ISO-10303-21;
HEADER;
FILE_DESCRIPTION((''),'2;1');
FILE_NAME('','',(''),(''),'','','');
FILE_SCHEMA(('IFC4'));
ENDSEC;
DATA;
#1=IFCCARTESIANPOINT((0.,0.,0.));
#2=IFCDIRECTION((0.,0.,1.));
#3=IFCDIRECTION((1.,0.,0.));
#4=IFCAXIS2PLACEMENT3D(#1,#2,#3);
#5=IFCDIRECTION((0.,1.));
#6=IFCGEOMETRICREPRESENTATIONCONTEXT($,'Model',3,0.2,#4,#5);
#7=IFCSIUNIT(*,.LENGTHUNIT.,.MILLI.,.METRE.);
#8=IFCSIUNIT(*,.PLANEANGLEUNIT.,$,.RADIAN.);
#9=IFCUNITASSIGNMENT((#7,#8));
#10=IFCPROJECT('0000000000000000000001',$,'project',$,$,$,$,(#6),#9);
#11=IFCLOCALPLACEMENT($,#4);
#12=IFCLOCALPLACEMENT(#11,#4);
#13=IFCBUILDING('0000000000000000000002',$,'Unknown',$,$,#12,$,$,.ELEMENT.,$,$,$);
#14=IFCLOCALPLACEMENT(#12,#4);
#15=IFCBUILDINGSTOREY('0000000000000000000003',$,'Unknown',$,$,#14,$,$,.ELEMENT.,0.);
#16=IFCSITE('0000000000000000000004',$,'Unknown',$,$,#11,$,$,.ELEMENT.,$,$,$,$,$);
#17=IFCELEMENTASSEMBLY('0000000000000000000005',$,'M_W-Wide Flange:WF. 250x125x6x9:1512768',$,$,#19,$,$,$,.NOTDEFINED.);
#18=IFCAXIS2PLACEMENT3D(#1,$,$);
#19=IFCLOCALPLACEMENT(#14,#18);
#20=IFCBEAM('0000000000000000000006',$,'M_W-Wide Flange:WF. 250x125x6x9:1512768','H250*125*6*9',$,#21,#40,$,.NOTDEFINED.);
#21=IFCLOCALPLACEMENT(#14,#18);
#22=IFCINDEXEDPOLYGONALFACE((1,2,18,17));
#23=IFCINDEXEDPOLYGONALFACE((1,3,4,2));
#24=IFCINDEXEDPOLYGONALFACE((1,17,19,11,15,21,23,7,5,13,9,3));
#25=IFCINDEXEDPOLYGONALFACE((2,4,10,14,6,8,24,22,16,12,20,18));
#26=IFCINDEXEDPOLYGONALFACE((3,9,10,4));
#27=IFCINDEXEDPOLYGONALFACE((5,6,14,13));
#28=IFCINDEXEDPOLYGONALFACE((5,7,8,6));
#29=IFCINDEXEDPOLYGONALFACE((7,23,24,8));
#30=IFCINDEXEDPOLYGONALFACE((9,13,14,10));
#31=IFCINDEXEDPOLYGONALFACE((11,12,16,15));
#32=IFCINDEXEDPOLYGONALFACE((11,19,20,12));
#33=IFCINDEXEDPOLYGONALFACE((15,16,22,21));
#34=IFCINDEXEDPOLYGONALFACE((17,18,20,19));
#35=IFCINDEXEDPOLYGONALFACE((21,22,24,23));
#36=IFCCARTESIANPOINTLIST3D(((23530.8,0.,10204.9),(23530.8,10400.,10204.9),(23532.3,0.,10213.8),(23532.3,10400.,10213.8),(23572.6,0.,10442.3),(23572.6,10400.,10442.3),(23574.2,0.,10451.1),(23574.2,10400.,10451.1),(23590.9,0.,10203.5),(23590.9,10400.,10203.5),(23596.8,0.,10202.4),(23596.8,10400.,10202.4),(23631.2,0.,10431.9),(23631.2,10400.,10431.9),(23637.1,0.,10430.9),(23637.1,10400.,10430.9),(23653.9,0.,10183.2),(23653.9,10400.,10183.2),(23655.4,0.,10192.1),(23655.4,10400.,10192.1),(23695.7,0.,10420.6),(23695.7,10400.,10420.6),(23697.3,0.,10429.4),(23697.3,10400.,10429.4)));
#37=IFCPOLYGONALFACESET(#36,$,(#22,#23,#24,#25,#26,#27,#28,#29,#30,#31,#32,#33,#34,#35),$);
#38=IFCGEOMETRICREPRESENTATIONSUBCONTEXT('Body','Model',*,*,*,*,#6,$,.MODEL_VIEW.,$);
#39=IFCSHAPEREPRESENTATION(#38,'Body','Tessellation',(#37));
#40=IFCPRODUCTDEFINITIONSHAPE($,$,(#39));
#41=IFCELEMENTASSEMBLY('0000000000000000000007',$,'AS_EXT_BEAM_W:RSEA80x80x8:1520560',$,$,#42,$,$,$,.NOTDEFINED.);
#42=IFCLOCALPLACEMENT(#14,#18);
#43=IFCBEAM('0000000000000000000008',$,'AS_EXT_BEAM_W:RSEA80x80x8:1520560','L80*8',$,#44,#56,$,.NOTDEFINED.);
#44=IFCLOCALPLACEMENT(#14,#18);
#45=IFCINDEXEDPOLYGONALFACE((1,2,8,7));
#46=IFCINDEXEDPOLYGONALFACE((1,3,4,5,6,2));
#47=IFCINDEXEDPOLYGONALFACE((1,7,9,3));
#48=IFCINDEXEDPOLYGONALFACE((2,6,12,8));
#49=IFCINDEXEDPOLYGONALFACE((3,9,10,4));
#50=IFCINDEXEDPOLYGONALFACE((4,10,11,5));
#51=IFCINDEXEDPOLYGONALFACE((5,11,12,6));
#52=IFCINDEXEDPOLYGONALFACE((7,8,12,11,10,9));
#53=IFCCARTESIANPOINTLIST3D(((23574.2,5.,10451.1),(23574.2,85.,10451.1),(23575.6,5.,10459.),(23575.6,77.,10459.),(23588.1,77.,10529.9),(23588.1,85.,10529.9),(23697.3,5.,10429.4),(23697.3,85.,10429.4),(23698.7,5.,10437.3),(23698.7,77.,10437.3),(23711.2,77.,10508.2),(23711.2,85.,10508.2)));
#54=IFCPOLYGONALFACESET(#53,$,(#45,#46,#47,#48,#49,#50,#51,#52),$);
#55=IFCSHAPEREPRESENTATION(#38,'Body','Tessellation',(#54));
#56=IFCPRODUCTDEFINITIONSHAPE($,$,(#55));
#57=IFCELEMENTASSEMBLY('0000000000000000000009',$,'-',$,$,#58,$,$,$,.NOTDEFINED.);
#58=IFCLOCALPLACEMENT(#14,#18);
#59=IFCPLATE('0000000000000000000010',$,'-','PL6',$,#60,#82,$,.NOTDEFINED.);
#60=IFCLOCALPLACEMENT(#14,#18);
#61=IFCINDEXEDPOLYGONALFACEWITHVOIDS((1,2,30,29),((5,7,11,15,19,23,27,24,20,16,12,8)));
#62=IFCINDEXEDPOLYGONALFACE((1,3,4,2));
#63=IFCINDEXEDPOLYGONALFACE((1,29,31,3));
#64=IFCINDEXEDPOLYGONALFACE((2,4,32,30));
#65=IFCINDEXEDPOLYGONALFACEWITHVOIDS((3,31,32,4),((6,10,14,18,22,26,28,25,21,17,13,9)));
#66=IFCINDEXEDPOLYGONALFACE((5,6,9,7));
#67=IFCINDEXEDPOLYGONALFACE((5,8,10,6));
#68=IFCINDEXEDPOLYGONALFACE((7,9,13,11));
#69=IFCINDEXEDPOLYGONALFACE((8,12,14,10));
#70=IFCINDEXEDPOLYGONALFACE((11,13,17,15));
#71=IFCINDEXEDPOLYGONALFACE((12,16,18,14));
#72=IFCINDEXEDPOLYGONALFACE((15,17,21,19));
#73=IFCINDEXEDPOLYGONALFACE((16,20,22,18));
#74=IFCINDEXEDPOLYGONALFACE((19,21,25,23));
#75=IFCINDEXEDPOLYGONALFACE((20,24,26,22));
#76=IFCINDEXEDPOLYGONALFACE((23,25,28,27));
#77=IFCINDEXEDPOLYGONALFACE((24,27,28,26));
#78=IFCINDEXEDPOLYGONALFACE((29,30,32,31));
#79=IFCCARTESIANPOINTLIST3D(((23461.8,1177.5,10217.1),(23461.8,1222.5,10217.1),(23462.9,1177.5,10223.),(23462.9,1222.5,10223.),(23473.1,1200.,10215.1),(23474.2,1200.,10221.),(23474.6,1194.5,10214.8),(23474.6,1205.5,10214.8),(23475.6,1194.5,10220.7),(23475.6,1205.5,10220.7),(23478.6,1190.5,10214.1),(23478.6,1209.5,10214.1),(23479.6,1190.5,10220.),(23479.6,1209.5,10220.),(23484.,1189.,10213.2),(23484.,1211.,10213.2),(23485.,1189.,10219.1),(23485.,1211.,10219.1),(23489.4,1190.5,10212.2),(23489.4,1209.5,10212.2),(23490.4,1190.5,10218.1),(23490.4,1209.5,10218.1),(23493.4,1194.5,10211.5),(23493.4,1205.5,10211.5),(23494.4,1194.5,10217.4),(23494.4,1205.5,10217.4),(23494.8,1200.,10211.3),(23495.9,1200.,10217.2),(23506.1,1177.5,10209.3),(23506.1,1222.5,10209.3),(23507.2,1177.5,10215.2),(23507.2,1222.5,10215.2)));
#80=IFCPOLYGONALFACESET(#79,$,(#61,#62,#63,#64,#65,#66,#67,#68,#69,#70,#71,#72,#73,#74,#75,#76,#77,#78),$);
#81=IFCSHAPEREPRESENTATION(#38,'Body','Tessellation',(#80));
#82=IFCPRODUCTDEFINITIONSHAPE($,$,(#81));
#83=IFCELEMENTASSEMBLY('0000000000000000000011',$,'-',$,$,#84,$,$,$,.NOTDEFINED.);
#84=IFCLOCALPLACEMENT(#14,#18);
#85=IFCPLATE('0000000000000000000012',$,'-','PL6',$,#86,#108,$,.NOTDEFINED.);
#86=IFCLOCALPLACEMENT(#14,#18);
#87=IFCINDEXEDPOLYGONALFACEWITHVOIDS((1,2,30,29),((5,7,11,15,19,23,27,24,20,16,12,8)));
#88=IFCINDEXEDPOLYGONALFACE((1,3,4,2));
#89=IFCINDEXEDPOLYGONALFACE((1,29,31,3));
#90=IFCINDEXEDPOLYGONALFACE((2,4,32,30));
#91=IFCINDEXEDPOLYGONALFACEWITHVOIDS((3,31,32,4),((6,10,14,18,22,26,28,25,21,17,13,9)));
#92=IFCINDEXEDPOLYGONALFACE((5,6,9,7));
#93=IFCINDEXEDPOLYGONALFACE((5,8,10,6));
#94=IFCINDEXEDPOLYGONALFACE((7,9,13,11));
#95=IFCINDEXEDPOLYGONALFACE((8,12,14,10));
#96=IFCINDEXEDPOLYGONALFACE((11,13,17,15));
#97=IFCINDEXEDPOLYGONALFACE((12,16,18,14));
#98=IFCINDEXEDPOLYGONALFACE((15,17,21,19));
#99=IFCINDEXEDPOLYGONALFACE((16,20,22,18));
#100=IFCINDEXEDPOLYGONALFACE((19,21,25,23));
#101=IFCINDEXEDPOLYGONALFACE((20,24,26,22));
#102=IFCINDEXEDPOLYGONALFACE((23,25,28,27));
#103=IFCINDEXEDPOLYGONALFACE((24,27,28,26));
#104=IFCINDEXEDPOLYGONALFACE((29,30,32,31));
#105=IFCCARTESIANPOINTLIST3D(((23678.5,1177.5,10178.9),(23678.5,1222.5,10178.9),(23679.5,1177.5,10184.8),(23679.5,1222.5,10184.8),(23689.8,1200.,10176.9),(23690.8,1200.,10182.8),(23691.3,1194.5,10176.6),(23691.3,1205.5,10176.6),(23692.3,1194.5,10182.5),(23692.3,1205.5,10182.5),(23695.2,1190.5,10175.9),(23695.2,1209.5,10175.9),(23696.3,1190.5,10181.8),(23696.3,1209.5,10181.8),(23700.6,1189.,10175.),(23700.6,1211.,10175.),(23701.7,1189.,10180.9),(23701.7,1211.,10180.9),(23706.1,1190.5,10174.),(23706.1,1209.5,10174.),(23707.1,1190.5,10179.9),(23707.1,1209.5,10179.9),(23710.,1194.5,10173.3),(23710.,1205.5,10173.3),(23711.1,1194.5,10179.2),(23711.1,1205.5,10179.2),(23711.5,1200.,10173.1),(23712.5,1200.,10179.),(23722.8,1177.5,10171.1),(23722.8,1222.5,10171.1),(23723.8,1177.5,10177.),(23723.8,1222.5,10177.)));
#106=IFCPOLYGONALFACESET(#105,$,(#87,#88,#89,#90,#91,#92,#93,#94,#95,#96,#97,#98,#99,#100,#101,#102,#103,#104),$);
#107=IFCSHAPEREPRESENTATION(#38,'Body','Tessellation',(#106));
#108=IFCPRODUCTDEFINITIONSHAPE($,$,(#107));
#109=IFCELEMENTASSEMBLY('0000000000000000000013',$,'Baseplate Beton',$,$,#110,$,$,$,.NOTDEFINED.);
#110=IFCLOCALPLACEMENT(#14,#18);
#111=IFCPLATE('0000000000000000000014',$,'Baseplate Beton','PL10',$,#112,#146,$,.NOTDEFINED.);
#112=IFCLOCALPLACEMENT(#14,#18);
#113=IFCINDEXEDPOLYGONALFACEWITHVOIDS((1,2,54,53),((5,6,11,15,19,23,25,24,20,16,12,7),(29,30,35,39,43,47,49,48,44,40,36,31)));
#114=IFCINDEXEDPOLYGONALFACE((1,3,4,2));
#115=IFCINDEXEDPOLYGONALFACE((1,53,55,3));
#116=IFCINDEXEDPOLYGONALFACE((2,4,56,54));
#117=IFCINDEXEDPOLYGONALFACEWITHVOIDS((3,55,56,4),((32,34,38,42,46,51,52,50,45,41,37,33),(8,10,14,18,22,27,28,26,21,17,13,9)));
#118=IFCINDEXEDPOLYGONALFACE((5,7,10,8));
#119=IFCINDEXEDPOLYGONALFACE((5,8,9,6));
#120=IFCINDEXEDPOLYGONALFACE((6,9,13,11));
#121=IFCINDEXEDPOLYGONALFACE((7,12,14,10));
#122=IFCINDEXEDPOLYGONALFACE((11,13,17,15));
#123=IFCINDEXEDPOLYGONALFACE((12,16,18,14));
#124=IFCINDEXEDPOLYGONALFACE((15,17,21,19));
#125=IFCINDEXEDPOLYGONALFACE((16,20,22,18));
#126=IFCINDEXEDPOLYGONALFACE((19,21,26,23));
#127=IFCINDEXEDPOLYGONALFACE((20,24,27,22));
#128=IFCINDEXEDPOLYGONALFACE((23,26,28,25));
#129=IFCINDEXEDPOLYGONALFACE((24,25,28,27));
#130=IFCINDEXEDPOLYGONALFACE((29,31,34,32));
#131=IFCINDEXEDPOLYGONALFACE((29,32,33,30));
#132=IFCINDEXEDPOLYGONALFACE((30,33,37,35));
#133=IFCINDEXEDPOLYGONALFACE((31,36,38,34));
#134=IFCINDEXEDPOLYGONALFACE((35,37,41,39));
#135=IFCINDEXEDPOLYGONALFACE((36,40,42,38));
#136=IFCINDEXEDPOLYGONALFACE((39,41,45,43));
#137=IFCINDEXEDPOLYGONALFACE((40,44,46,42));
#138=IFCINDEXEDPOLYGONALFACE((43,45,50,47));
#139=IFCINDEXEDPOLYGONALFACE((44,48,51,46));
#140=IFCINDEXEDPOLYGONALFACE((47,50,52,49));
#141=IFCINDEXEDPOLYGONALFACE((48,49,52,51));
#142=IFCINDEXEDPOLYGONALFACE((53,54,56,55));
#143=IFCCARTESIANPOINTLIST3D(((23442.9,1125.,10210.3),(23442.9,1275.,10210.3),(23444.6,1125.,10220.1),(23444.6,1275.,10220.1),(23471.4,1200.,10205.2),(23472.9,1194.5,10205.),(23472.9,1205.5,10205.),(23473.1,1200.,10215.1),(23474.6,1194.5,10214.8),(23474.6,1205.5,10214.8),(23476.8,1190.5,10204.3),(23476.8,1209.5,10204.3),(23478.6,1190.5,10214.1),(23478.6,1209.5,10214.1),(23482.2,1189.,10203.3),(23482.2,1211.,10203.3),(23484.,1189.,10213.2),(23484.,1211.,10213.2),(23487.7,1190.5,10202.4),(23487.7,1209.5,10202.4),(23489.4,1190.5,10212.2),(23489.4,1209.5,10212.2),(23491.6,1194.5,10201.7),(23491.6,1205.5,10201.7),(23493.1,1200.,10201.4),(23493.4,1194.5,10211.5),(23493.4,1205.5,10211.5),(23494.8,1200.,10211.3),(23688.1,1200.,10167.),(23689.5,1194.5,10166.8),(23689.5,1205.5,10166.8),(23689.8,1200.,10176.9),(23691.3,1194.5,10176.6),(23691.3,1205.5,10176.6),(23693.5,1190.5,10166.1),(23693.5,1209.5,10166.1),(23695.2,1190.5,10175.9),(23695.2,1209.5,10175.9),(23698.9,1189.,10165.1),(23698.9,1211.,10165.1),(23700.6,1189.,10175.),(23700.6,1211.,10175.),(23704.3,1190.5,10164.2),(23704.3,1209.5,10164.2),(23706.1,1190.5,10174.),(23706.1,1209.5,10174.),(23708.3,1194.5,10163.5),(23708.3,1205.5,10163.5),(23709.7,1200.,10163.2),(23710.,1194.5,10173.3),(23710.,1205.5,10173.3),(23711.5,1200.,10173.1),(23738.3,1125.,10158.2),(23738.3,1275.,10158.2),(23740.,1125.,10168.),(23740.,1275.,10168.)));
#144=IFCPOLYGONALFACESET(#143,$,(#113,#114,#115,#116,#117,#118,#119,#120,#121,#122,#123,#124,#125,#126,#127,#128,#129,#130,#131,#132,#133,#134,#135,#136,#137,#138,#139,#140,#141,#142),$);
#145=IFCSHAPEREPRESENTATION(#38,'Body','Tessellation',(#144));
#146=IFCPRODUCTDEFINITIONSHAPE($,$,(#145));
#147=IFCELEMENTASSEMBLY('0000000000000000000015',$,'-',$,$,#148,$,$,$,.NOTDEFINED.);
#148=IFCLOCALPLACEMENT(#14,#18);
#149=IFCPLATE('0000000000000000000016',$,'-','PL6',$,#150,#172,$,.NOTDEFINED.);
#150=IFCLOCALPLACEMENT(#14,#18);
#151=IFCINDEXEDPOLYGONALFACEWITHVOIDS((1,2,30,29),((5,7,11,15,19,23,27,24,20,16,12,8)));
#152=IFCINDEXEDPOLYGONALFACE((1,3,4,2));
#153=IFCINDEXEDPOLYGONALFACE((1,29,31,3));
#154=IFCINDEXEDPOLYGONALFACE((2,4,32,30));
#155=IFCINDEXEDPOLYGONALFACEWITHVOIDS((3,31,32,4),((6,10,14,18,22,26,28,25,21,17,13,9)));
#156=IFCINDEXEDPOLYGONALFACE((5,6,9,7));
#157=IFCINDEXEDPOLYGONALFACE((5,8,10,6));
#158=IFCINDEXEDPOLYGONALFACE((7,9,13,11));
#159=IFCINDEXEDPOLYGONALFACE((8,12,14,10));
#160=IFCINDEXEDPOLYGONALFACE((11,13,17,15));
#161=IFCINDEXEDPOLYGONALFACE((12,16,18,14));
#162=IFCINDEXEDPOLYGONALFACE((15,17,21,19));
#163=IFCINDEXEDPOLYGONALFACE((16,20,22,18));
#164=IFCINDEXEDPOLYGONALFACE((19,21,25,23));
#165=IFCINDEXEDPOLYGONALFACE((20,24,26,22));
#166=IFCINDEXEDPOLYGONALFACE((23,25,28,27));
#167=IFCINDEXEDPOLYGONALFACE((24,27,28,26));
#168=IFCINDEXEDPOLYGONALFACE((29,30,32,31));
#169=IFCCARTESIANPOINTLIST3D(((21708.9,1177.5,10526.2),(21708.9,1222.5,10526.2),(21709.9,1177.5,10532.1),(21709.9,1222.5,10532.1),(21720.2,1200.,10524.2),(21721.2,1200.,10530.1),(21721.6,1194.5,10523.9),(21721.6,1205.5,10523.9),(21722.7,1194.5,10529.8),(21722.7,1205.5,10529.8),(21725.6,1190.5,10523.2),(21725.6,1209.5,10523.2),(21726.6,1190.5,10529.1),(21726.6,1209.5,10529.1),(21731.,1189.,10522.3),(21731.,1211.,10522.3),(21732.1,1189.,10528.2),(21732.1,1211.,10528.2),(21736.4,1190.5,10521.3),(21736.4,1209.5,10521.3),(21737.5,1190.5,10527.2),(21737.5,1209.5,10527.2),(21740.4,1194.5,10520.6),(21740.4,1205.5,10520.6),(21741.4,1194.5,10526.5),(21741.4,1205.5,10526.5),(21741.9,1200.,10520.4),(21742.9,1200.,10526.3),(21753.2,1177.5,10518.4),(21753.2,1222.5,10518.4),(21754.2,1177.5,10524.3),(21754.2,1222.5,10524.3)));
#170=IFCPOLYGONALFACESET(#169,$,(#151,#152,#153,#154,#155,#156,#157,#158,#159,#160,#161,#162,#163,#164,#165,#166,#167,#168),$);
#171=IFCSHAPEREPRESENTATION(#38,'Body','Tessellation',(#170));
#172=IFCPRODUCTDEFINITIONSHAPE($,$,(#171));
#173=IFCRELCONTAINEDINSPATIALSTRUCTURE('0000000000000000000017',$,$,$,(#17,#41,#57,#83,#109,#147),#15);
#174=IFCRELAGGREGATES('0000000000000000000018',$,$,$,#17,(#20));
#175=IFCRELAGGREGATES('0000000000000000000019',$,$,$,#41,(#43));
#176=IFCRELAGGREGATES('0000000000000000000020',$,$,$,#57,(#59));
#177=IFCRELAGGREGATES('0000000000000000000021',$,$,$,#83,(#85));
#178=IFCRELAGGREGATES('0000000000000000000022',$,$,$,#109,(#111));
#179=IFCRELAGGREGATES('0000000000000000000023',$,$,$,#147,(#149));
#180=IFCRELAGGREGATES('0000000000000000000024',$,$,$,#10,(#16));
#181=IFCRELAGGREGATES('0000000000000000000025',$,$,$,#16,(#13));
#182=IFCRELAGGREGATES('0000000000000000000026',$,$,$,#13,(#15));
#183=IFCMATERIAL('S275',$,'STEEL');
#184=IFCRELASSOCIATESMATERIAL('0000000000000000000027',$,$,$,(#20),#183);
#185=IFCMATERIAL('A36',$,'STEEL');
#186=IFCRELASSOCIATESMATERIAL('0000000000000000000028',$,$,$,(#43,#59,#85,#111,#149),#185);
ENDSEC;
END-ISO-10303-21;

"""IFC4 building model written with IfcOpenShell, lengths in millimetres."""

from ifc_helpers import new_model, si_unit, direction, frame, origin_with_axes, place, context, subcontext, project, spatial, line, indexed_curve, outline, extrude, material, element, aggregate, save


model = new_model("IFC4")

# Units and contexts
model_context = context("Model", 3, precision=0.2, world=origin_with_axes(), true_north=direction((0.0, 1.0)))
body_context = subcontext(model_context, "Body", "Model", "MODEL_VIEW")
ifc_project = project(units=[si_unit("LENGTHUNIT", "METRE", prefix="MILLI"), si_unit("PLANEANGLEUNIT", "RADIAN")], contexts=[model_context])

# Site, building, storey
site_placement = place(None, origin_with_axes())
site = spatial("IfcSite", under=ifc_project, at=site_placement, Name="Unknown", CompositionType="ELEMENT")
building_placement = place(site_placement, origin_with_axes())
building = spatial("IfcBuilding", under=site, at=building_placement, Name="Unknown", CompositionType="ELEMENT")
storey_placement = place(building_placement, origin_with_axes())
storey = spatial("IfcBuildingStorey", under=building, at=storey_placement, Name="Unknown", CompositionType="ELEMENT", Elevation=0.0)

# Shared definitions
ifc_material_1 = material(Name="S275", Category="STEEL")

# Element assemblies, beams
ifc_material_2 = material(Name="A36", Category="STEEL")
assembly_1_placement = place(storey_placement, frame((23614.0, 0.0, 10317.2), z_axis=(0.984808, 0.0, -0.173648), x_axis=(0.0, 1.0, 0.0)))
assembly_1 = element("IfcElementAssembly", 1, at=assembly_1_placement, inside=storey, Name="M_W-Wide Flange:WF. 250x125x6x9:1512768", PredefinedType="NOTDEFINED")
beam_1_placement = place(assembly_1_placement, origin_with_axes())
beam_1 = element("IfcBeam", 2, at=beam_1_placement, material=ifc_material_1, Name="M_W-Wide Flange:WF. 250x125x6x9:1512768", Description="H250*125*6*9", PredefinedType="NOTDEFINED", context=body_context, shape_type="SolidModel", body=[
    extrude(outline(indexed_curve([(-62.5, -125.0), (62.5, -125.0), (62.5, -116.0), (3.0, -116.0), (3.0, 116.0), (62.5, 116.0), (62.5, 125.0), (-62.5, 125.0), (-62.5, 116.0), (-3.0, 116.0), (-3.0, -116.0), (-62.5, -116.0)], segments=[line(1, 2, 3, 4, 5, 6, 7, 8, 9, 10, 11, 12, 1)])), frame((0.0, 0.0, 0.0), z_axis=(-1.0, 0.0, 0.0), x_axis=(0.0, 0.0, 1.0)), (0.0, 0.0, -1.0), 10400.0),
])
aggregate(assembly_1, [beam_1])
assembly_2_placement = place(storey_placement, frame((23581.1, 45.0, 10490.5), z_axis=(0.0, -1.0, 0.0), x_axis=(0.984808, 0.0, -0.173648)))
assembly_2 = element("IfcElementAssembly", 3, at=assembly_2_placement, inside=storey, Name="AS_EXT_BEAM_W:RSEA80x80x8:1520560", PredefinedType="NOTDEFINED")
beam_2_placement = place(assembly_2_placement, origin_with_axes())
beam_2 = element("IfcBeam", 4, at=beam_2_placement, material=ifc_material_2, Name="AS_EXT_BEAM_W:RSEA80x80x8:1520560", Description="L80*8", PredefinedType="NOTDEFINED", context=body_context, shape_type="SolidModel", body=[
    extrude(outline(indexed_curve([(-40.0, -40.0), (40.0, -40.0), (40.0, -32.0), (-32.0, -32.0), (-32.0, 40.0), (-40.0, 40.0)], segments=[line(1, 2, 3, 4, 5, 6, 1)])), frame((0.0, 0.0, 0.0), z_axis=(-1.0, 0.0, 0.0), x_axis=(0.0, 0.0, 1.0)), (0.0, 0.0, -1.0), 125.0),
])
aggregate(assembly_2, [beam_2])

# Element assemblies, plates, voiding features
assembly_3_placement = place(storey_placement, frame((23506.7, 1177.5, 10212.2), z_axis=(0.173648, 0.0, 0.984808), x_axis=(0.0, 1.0, 0.0)))
assembly_3 = element("IfcElementAssembly", 5, at=assembly_3_placement, inside=storey, Name="-", PredefinedType="NOTDEFINED")
plate_1_placement = place(assembly_3_placement, origin_with_axes())
plate_1 = element("IfcPlate", 6, at=plate_1_placement, material=ifc_material_2, Name="-", Description="PL6", PredefinedType="NOTDEFINED", context=body_context, shape_type="SolidModel", body=[
    extrude(outline(indexed_curve([(0.0, 0.0), (45.0, 0.0), (45.0, 45.0), (0.0, 45.0)], segments=[line(1, 2, 3, 4, 1)])), frame((0.0, 0.0, 3.0), z_axis=(0.0, 0.0, 1.0), x_axis=(1.0, 0.0, 0.0)), (0.0, 0.0, -1.0), 6.0),
])
voiding_feature_1_placement = place(plate_1_placement, frame((22.5, 22.5, 3.5), z_axis=(1.0, 0.0, 0.0), x_axis=(0.0, 0.0, -1.0)))
element("IfcVoidingFeature", 7, at=voiding_feature_1_placement, cuts=plate_1, Name="BEAM", PredefinedType="HOLE", context=body_context, shape_type="SolidModel", body=[
    extrude(outline(indexed_curve([(11.0, 0.0), (9.5, 5.5), (5.5, 9.5), (0.0, 11.0), (-5.5, 9.5), (-9.5, 5.5), (-11.0, 0.0), (-9.5, -5.5), (-5.5, -9.5), (0.0, -11.0), (5.5, -9.5), (9.5, -5.5)], segments=[line(1, 2, 3, 4, 5, 6, 7, 8, 9, 10, 11, 12, 1)])), frame((0.0, 0.0, 0.0), z_axis=(-1.0, 0.0, 0.0), x_axis=(0.0, 0.0, 1.0)), (0.0, 0.0, -1.0), 7.0),
])
aggregate(assembly_3, [plate_1])
assembly_4_placement = place(storey_placement, frame((23679.0, 1177.5, 10181.8), z_axis=(-0.173648, 0.0, -0.984808), x_axis=(0.0, 1.0, 0.0)))
assembly_4 = element("IfcElementAssembly", 8, at=assembly_4_placement, inside=storey, Name="-", PredefinedType="NOTDEFINED")
plate_2_placement = place(assembly_4_placement, origin_with_axes())
plate_2 = element("IfcPlate", 9, at=plate_2_placement, material=ifc_material_2, Name="-", Description="PL6", PredefinedType="NOTDEFINED", context=body_context, shape_type="SolidModel", body=[
    extrude(outline(indexed_curve([(0.0, 0.0), (45.0, 0.0), (45.0, 45.0), (0.0, 45.0)], segments=[line(1, 2, 3, 4, 1)])), frame((0.0, 0.0, 3.0), z_axis=(0.0, 0.0, 1.0), x_axis=(1.0, 0.0, 0.0)), (0.0, 0.0, -1.0), 6.0),
])
voiding_feature_2_placement = place(plate_2_placement, frame((22.5, 22.5, -3.5), z_axis=(-1.0, 0.0, 0.0), x_axis=(0.0, 0.0, 1.0)))
element("IfcVoidingFeature", 10, at=voiding_feature_2_placement, cuts=plate_2, Name="BEAM", PredefinedType="HOLE", context=body_context, shape_type="SolidModel", body=[
    extrude(outline(indexed_curve([(11.0, 0.0), (9.5, 5.5), (5.5, 9.5), (0.0, 11.0), (-5.5, 9.5), (-9.5, 5.5), (-11.0, 0.0), (-9.5, -5.5), (-5.5, -9.5), (0.0, -11.0), (5.5, -9.5), (9.5, -5.5)], segments=[line(1, 2, 3, 4, 5, 6, 7, 8, 9, 10, 11, 12, 1)])), frame((0.0, 0.0, 0.0), z_axis=(-1.0, 0.0, 0.0), x_axis=(0.0, 0.0, 1.0)), (0.0, 0.0, -1.0), 7.0),
])
aggregate(assembly_4, [plate_2])

# Element assembly, plate, voiding features
assembly_5_placement = place(storey_placement, frame((23739.2, 1125.0, 10163.1), z_axis=(0.173648, 0.0, 0.984808), x_axis=(0.0, 1.0, 0.0)))
assembly_5 = element("IfcElementAssembly", 11, at=assembly_5_placement, inside=storey, Name="Baseplate Beton", PredefinedType="NOTDEFINED")
plate_3_placement = place(assembly_5_placement, origin_with_axes())
plate_3 = element("IfcPlate", 12, at=plate_3_placement, material=ifc_material_2, Name="Baseplate Beton", Description="PL10", PredefinedType="NOTDEFINED", context=body_context, shape_type="SolidModel", body=[
    extrude(outline(indexed_curve([(0.0, 0.0), (150.0, 0.0), (150.0, 300.0), (0.0, 300.0)], segments=[line(1, 2, 3, 4, 1)])), frame((0.0, 0.0, 5.0), z_axis=(0.0, 0.0, 1.0), x_axis=(1.0, 0.0, 0.0)), (0.0, 0.0, -1.0), 10.0),
])
voiding_feature_3_placement = place(plate_3_placement, frame((75.0, 260.0, 5.5), z_axis=(1.0, 0.0, 0.0), x_axis=(0.0, 0.0, -1.0)))
element("IfcVoidingFeature", 13, at=voiding_feature_3_placement, cuts=plate_3, Name="BEAM", PredefinedType="HOLE", context=body_context, shape_type="SolidModel", body=[
    extrude(outline(indexed_curve([(11.0, 0.0), (9.5, 5.5), (5.5, 9.5), (0.0, 11.0), (-5.5, 9.5), (-9.5, 5.5), (-11.0, 0.0), (-9.5, -5.5), (-5.5, -9.5), (0.0, -11.0), (5.5, -9.5), (9.5, -5.5)], segments=[line(1, 2, 3, 4, 5, 6, 7, 8, 9, 10, 11, 12, 1)])), frame((0.0, 0.0, 0.0), z_axis=(-1.0, 0.0, 0.0), x_axis=(0.0, 0.0, 1.0)), (0.0, 0.0, -1.0), 11.0),
])
voiding_feature_4_placement = place(plate_3_placement, frame((75.0, 40.0, 5.5), z_axis=(1.0, 0.0, 0.0), x_axis=(0.0, 0.0, -1.0)))
element("IfcVoidingFeature", 14, at=voiding_feature_4_placement, cuts=plate_3, Name="BEAM", PredefinedType="HOLE", context=body_context, shape_type="SolidModel", body=[
    extrude(outline(indexed_curve([(11.0, 0.0), (9.5, 5.5), (5.5, 9.5), (0.0, 11.0), (-5.5, 9.5), (-9.5, 5.5), (-11.0, 0.0), (-9.5, -5.5), (-5.5, -9.5), (0.0, -11.0), (5.5, -9.5), (9.5, -5.5)], segments=[line(1, 2, 3, 4, 5, 6, 7, 8, 9, 10, 11, 12, 1)])), frame((0.0, 0.0, 0.0), z_axis=(-1.0, 0.0, 0.0), x_axis=(0.0, 0.0, 1.0)), (0.0, 0.0, -1.0), 11.0),
])
aggregate(assembly_5, [plate_3])

# Element assembly, plate, voiding feature
assembly_6_placement = place(storey_placement, frame((21709.4, 1177.5, 10529.1), z_axis=(-0.173648, 0.0, -0.984808), x_axis=(0.0, 1.0, 0.0)))
assembly_6 = element("IfcElementAssembly", 15, at=assembly_6_placement, inside=storey, Name="-", PredefinedType="NOTDEFINED")
plate_4_placement = place(assembly_6_placement, origin_with_axes())
plate_4 = element("IfcPlate", 16, at=plate_4_placement, material=ifc_material_2, Name="-", Description="PL6", PredefinedType="NOTDEFINED", context=body_context, shape_type="SolidModel", body=[
    extrude(outline(indexed_curve([(0.0, 0.0), (45.0, 0.0), (45.0, 45.0), (0.0, 45.0)], segments=[line(1, 2, 3, 4, 1)])), frame((0.0, 0.0, 3.0), z_axis=(0.0, 0.0, 1.0), x_axis=(1.0, 0.0, 0.0)), (0.0, 0.0, -1.0), 6.0),
])
voiding_feature_5_placement = place(plate_4_placement, frame((22.5, 22.5, -3.5), z_axis=(-1.0, 0.0, 0.0), x_axis=(0.0, 0.0, 1.0)))
element("IfcVoidingFeature", 17, at=voiding_feature_5_placement, cuts=plate_4, Name="BEAM", PredefinedType="HOLE", context=body_context, shape_type="SolidModel", body=[
    extrude(outline(indexed_curve([(11.0, 0.0), (9.5, 5.5), (5.5, 9.5), (0.0, 11.0), (-5.5, 9.5), (-9.5, 5.5), (-11.0, 0.0), (-9.5, -5.5), (-5.5, -9.5), (0.0, -11.0), (5.5, -9.5), (9.5, -5.5)], segments=[line(1, 2, 3, 4, 5, 6, 7, 8, 9, 10, 11, 12, 1)])), frame((0.0, 0.0, 0.0), z_axis=(-1.0, 0.0, 0.0), x_axis=(0.0, 0.0, 1.0)), (0.0, 0.0, -1.0), 7.0),
])
aggregate(assembly_6, [plate_4])

save(model, "model.ifc")
